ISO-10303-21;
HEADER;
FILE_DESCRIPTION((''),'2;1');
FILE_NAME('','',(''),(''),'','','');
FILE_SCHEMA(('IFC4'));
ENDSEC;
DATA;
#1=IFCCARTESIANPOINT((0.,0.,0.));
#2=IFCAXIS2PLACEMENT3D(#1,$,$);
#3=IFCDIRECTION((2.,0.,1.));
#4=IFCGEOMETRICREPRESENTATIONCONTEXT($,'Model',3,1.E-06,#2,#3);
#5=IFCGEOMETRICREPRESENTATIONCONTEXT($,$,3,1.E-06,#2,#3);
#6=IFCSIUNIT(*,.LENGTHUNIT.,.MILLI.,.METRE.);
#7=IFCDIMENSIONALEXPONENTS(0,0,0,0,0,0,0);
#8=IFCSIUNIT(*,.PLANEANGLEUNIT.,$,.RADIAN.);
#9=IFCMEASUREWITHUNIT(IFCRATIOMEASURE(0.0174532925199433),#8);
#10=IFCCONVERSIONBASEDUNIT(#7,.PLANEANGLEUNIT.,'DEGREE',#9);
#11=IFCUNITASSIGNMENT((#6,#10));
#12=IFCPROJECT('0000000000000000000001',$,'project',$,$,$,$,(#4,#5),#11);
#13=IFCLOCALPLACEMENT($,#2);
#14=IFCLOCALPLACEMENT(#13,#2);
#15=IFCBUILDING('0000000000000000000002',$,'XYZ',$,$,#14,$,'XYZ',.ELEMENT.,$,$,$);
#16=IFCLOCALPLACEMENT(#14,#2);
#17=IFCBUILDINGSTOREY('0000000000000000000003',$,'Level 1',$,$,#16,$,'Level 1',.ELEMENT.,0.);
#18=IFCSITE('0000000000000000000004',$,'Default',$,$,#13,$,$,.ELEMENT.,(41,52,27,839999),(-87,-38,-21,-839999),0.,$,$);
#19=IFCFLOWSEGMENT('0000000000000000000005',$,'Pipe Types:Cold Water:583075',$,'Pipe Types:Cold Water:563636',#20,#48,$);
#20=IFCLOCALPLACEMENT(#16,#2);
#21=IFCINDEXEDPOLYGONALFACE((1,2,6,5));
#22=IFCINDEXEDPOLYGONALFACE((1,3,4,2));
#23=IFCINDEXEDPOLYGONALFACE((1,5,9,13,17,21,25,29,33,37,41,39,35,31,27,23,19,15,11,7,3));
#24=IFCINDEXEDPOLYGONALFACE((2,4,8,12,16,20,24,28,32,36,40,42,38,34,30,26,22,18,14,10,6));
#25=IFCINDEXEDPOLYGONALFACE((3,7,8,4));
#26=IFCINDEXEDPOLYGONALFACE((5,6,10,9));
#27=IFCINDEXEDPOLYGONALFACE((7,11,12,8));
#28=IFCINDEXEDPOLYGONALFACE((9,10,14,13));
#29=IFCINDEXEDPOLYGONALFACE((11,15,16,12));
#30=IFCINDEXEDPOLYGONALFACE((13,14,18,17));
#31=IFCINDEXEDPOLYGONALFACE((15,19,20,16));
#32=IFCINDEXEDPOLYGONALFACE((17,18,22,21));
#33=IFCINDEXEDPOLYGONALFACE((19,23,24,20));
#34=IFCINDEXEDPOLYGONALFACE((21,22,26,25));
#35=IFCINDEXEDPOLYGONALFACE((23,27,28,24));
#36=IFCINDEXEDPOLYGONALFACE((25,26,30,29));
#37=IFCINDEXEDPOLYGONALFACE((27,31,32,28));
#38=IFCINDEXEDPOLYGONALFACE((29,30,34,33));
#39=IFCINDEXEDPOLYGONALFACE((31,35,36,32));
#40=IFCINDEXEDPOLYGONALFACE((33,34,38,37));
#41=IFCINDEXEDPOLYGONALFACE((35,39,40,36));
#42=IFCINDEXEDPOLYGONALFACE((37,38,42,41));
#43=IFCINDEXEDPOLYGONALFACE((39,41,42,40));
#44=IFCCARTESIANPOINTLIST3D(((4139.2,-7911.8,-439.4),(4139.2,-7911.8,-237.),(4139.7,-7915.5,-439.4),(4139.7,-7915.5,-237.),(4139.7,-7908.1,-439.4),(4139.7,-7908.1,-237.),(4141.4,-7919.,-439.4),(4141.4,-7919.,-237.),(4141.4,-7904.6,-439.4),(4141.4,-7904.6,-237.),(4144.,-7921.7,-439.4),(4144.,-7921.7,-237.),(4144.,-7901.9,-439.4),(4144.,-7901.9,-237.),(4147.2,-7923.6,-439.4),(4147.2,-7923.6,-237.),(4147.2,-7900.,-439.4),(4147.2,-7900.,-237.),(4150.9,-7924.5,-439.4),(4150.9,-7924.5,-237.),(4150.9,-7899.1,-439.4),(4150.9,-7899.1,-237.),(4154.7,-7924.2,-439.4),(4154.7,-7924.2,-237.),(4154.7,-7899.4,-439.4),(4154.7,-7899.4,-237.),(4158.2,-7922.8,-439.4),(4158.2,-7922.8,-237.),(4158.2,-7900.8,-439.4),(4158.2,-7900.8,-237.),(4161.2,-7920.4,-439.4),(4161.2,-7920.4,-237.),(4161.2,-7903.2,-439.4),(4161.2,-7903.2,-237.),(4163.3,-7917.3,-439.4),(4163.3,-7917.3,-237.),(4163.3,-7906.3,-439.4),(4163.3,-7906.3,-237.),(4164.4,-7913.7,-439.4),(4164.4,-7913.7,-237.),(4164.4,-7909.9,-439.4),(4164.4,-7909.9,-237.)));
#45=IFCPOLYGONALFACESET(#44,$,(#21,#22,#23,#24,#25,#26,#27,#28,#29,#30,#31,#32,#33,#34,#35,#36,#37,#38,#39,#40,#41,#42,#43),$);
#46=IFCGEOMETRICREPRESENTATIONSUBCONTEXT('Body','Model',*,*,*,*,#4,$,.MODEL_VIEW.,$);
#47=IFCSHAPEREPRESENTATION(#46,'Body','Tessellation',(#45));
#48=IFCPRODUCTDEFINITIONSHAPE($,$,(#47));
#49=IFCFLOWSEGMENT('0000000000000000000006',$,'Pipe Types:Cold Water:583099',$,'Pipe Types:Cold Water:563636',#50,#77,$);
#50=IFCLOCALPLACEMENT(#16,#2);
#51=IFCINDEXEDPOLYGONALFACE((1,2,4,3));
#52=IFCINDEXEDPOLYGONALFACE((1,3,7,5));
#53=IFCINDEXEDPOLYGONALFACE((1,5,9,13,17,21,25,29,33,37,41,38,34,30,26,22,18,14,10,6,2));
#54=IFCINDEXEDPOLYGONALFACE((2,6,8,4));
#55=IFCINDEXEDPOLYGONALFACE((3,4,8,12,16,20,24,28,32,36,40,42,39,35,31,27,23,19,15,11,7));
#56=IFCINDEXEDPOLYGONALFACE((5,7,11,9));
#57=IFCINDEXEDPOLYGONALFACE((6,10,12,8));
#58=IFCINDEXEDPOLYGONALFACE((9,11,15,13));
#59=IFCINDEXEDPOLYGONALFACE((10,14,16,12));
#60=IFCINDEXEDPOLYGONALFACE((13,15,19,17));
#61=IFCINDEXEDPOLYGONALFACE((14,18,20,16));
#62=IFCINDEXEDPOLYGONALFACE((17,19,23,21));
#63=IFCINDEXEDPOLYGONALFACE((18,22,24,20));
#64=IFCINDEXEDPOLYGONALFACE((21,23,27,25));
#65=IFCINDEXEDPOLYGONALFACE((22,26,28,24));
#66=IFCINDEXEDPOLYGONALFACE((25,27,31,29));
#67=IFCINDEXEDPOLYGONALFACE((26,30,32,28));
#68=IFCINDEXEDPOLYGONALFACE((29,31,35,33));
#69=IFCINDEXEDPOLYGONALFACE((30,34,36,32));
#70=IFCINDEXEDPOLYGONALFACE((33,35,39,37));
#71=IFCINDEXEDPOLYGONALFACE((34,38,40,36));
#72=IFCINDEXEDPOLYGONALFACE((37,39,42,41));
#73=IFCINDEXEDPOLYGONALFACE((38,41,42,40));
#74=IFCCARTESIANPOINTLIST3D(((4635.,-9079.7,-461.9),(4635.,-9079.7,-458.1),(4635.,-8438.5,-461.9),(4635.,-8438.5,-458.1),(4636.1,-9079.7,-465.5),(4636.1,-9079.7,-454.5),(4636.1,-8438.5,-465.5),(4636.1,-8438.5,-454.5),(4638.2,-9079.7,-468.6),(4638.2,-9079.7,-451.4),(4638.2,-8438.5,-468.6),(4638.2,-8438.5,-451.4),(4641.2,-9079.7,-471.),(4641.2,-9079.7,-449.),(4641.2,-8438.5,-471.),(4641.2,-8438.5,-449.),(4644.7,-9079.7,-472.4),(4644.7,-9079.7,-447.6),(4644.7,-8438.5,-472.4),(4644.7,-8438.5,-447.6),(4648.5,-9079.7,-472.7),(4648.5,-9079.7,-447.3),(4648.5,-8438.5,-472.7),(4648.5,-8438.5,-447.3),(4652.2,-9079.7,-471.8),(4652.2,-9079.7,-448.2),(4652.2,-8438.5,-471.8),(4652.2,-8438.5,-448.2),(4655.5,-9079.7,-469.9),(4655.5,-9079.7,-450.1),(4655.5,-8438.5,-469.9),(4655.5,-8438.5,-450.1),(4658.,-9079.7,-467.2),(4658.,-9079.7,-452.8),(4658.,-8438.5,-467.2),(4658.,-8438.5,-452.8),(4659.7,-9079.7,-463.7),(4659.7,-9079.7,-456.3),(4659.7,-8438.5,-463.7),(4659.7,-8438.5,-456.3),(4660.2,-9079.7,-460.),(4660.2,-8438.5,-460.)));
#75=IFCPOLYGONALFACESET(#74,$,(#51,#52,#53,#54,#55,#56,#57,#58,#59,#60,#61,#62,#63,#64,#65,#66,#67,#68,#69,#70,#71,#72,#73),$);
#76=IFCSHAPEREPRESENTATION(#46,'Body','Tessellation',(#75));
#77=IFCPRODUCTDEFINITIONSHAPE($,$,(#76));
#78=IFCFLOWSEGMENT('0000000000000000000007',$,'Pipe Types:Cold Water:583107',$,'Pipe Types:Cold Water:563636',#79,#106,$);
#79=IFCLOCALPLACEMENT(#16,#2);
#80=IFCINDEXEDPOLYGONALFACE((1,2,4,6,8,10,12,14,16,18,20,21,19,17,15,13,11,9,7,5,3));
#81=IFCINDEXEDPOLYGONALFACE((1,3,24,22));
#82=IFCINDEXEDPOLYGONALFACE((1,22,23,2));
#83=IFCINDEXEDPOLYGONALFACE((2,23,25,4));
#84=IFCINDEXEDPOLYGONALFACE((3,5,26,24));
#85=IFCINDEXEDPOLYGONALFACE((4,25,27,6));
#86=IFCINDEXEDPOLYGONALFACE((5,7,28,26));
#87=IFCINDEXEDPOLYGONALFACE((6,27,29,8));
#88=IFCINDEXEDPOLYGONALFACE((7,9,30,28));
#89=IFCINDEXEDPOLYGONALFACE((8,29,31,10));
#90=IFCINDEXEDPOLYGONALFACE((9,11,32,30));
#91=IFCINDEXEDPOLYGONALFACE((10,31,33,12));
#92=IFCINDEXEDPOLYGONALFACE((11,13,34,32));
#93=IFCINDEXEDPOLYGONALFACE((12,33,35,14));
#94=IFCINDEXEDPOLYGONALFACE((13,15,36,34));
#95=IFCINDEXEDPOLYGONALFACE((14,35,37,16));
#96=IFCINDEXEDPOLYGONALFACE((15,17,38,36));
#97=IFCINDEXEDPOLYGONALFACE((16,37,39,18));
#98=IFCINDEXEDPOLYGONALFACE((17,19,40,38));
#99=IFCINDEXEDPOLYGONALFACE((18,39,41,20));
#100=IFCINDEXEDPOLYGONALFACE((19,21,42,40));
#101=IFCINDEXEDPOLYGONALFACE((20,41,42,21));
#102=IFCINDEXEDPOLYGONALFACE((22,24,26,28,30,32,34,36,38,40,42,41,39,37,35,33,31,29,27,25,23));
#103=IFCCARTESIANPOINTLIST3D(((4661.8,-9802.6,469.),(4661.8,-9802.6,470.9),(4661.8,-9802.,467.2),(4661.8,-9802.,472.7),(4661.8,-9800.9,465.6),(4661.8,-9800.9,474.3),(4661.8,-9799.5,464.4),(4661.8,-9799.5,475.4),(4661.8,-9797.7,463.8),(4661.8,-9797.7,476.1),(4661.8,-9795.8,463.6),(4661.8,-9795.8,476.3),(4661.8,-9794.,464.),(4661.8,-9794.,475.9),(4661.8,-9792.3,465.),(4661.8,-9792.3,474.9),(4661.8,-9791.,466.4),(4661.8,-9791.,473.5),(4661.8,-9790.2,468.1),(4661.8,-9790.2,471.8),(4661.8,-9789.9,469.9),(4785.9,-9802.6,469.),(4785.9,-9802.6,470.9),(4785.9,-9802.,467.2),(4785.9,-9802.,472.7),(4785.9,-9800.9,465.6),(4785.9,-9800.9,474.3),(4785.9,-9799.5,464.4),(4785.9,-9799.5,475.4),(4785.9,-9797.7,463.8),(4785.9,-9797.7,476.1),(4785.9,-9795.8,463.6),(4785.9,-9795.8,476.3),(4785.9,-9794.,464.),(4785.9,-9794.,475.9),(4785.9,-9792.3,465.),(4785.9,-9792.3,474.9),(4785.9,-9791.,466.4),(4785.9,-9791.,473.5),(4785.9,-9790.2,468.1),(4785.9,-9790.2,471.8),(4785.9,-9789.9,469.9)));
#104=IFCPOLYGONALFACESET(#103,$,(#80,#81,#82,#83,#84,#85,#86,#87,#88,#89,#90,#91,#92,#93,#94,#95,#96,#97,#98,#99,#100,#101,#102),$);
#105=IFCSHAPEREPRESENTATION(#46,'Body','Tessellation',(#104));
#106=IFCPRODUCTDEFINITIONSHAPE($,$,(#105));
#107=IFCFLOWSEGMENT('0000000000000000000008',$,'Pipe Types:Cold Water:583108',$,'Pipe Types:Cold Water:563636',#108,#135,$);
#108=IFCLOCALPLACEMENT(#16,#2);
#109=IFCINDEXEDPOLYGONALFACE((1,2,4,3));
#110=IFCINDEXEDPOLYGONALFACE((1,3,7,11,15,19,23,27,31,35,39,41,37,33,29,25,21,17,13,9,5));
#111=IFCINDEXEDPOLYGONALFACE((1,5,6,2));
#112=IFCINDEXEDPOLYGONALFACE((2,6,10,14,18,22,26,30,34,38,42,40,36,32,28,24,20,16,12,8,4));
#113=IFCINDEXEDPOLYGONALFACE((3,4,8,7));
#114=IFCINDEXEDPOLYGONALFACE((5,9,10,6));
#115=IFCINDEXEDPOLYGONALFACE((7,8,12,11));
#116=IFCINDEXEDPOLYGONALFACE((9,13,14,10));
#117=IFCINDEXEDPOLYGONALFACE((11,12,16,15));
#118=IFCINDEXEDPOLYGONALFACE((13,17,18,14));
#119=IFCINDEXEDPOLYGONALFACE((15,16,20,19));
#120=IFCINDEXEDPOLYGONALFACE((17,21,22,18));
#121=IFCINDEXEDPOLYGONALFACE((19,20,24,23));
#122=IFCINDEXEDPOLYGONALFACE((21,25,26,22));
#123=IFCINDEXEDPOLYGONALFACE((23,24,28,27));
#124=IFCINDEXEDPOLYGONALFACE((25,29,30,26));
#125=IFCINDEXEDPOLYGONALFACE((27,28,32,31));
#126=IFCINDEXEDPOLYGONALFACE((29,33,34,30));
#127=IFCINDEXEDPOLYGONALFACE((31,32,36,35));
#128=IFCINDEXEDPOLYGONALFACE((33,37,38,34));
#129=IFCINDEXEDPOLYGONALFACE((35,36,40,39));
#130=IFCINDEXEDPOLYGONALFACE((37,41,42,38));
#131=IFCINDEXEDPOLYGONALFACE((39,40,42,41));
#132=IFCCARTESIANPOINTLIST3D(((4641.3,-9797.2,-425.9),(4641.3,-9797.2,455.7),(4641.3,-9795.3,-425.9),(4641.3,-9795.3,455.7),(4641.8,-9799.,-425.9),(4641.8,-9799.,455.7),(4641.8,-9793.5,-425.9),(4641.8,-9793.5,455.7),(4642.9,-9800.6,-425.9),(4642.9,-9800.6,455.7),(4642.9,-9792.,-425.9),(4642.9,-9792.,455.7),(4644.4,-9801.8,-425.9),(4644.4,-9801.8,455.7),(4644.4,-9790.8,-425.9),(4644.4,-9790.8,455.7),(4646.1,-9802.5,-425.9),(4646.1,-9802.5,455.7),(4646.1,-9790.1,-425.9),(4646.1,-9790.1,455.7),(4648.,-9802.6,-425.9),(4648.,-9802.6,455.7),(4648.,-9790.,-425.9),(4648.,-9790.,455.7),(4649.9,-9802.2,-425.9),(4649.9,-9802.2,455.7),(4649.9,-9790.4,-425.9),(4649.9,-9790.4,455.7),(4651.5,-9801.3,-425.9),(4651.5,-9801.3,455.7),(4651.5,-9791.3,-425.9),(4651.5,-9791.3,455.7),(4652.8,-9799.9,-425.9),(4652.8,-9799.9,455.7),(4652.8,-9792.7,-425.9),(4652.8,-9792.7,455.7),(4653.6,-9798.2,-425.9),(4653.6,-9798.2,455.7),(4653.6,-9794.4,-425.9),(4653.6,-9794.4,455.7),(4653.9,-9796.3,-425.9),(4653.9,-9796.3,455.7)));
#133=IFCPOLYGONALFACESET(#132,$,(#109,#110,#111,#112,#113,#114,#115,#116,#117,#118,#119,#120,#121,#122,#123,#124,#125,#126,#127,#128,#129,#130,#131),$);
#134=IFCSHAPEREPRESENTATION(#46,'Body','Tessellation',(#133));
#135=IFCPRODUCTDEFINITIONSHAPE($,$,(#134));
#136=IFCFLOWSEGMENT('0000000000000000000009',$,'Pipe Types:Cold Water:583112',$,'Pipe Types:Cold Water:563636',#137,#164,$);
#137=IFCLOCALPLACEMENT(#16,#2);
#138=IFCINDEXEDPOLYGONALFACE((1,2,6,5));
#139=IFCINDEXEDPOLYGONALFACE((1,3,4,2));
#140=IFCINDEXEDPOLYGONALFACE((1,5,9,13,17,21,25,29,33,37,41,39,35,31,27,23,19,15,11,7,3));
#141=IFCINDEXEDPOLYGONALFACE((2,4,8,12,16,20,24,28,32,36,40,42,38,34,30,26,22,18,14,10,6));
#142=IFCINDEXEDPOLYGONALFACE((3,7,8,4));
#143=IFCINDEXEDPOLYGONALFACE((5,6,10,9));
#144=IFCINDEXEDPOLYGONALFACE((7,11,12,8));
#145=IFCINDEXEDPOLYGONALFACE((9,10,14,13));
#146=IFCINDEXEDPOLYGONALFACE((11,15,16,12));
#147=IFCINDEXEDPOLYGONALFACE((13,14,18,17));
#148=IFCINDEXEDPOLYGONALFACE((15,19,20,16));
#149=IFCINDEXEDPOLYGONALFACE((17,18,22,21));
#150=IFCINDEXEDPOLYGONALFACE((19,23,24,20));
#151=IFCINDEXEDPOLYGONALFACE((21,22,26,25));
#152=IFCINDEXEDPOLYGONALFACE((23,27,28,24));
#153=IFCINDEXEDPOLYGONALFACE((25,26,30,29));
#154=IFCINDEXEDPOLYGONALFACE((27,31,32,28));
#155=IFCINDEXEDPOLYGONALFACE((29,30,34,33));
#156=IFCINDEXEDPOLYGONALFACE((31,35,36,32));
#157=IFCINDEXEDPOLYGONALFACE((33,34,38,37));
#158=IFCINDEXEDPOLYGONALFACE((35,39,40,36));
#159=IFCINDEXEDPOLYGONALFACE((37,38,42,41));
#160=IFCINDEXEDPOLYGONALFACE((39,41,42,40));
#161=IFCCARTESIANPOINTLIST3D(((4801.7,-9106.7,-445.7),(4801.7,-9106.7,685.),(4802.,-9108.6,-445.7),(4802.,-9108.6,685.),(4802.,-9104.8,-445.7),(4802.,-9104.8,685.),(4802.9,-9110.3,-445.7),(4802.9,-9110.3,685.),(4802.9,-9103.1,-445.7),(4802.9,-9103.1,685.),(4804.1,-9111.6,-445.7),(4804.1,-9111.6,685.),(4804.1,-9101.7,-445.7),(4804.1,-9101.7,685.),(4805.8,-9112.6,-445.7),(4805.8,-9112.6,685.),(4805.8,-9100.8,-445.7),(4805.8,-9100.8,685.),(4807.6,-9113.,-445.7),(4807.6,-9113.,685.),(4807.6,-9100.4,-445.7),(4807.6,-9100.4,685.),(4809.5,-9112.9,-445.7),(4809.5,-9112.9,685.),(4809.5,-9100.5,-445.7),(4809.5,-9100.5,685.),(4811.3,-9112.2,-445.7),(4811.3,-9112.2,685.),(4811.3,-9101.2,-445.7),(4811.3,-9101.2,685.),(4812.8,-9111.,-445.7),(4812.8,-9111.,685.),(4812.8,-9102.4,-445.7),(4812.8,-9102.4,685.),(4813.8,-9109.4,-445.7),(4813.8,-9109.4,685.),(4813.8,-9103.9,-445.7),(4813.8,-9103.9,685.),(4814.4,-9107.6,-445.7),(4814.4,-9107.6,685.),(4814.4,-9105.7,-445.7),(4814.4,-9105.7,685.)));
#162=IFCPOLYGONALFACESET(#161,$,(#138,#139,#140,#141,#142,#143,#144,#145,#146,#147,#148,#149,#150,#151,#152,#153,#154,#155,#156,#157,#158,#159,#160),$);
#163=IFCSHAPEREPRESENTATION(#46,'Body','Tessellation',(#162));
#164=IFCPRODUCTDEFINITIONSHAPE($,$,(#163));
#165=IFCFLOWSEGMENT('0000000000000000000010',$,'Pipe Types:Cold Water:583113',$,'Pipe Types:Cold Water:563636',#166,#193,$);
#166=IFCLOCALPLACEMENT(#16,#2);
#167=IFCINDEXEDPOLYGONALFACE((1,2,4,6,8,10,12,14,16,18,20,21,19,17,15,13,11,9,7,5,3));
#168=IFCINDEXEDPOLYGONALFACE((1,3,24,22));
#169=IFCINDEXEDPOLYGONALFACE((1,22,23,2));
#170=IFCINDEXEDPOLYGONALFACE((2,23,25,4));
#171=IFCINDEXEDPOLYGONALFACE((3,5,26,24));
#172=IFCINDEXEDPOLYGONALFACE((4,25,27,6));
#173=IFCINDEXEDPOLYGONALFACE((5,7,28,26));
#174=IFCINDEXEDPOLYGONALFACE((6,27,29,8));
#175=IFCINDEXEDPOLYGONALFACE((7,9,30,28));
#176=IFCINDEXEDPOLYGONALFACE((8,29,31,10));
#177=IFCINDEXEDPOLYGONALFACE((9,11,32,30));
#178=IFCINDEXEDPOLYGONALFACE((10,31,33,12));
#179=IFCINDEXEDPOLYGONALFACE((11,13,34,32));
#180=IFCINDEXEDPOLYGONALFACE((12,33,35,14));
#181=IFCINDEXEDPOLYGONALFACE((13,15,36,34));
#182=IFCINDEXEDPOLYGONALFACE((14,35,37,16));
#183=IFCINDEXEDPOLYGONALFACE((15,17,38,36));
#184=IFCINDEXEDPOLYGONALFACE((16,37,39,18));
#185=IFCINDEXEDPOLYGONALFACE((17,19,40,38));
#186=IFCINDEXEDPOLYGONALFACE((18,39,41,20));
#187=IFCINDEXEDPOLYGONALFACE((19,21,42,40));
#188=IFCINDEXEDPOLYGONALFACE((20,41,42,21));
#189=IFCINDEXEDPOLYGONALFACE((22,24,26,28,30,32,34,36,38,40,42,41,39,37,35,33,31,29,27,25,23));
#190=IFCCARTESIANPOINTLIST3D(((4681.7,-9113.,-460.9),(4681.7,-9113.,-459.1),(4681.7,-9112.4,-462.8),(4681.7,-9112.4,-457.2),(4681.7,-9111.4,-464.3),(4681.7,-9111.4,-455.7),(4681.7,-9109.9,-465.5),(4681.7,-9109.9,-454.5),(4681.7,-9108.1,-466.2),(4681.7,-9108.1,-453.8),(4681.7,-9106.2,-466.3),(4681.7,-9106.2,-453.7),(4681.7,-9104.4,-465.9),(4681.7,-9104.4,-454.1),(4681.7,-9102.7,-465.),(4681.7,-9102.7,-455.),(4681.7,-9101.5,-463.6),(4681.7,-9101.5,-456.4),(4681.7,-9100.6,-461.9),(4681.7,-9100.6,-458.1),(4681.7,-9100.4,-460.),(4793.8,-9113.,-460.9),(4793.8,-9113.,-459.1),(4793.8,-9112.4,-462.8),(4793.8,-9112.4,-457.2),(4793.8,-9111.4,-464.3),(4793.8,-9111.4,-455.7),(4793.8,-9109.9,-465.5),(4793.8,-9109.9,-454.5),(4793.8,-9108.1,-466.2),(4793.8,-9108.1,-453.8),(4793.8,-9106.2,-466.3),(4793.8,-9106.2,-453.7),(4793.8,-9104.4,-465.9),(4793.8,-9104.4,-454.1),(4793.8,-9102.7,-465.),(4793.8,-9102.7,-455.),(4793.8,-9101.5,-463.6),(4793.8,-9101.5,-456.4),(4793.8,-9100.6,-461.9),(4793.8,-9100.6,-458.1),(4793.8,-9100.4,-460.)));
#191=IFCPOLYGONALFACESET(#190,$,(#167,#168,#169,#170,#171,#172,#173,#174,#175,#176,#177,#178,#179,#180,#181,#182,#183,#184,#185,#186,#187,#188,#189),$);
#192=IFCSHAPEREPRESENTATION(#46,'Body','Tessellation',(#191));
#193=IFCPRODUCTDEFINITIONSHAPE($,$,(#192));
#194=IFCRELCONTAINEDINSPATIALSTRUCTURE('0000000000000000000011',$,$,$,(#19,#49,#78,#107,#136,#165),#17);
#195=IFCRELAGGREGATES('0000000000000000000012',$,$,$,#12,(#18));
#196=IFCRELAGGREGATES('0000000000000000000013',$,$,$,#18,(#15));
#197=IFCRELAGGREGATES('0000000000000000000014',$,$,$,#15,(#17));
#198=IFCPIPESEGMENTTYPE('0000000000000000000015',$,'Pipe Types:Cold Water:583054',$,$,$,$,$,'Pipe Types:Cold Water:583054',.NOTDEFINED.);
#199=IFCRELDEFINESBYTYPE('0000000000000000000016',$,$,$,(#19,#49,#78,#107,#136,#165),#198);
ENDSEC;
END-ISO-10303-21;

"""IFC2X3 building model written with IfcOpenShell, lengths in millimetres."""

from ifc_helpers import new_model, entity, si_unit, converted_unit, direction, frame, frame_2d, origin, origin_2d_with_axis, place, context, subcontext, project, spatial, circle, extrude, type_object, element, save


model = new_model("IFC2X3")

# Units and contexts
model_context = context("Model", 3, precision=1e-06, world=origin(), true_north=direction((2.0, 0.0, 1.0)))
context_of_model = context(None, 3, precision=1e-06, world=origin(), true_north=direction((2.0, 0.0, 1.0)))
body_context = subcontext(model_context, "Body", "Model", "MODEL_VIEW")
ifc_project = project(units=[si_unit("LENGTHUNIT", "METRE", prefix="MILLI"), converted_unit("PLANEANGLEUNIT", "DEGREE", entity("IfcRatioMeasure", 0.0174532925199433), si_unit("PLANEANGLEUNIT", "RADIAN"), dimensions=[0, 0, 0, 0, 0, 0, 0])], contexts=[model_context, context_of_model])

# Site, building, storey
site_placement = place(None, origin())
site = spatial("IfcSite", under=ifc_project, at=site_placement, Name="Default", CompositionType="ELEMENT", RefLatitude=(41, 52, 27, 839999), RefLongitude=(-87, -38, -21, -839999), RefElevation=0.0)
building_placement = place(site_placement, origin())
building = spatial("IfcBuilding", under=site, at=building_placement, Name="XYZ", LongName="XYZ", CompositionType="ELEMENT")
storey_placement = place(building_placement, origin())
storey = spatial("IfcBuildingStorey", under=building, at=storey_placement, Name="Level 1", LongName="Level 1", CompositionType="ELEMENT", Elevation=0.0)

# Flow segments
pipe_segment_type_1 = type_object("IfcPipeSegmentType", Name="Pipe Types:Cold Water:583054", ElementType="Pipe Types:Cold Water:583054", PredefinedType="NOTDEFINED")
flow_segment_1_placement = place(storey_placement, origin())
element("IfcFlowSegment", 1, at=flow_segment_1_placement, inside=storey, type_object=pipe_segment_type_1, Name="Pipe Types:Cold Water:583075", ObjectType="Pipe Types:Cold Water:563636", context=body_context, shape_type="SweptSolid", body=[
    extrude(circle(Radius=12.7, at=frame_2d((0.0, 0.0), x_axis=(1.0, 0.0))), frame((4151.9, -7911.8, -439.4), z_axis=(0.0, 0.0, 1.0), x_axis=(-1.0, 0.0, 0.0)), (0.0, 0.0, 1.0), 202.4),
])
flow_segment_2_placement = place(storey_placement, origin())
element("IfcFlowSegment", 2, at=flow_segment_2_placement, inside=storey, type_object=pipe_segment_type_1, Name="Pipe Types:Cold Water:583099", ObjectType="Pipe Types:Cold Water:563636", context=body_context, shape_type="SweptSolid", body=[
    extrude(circle(Radius=12.7, at=origin_2d_with_axis()), frame((4647.5, -9079.7, -460.0), z_axis=(0.0, 1.0, 0.0), x_axis=(1.0, 0.0, 0.0)), (0.0, 0.0, 1.0), 641.2),
])
flow_segment_3_placement = place(storey_placement, origin())
element("IfcFlowSegment", 3, at=flow_segment_3_placement, inside=storey, type_object=pipe_segment_type_1, Name="Pipe Types:Cold Water:583107", ObjectType="Pipe Types:Cold Water:563636", context=body_context, shape_type="SweptSolid", body=[
    extrude(circle(Radius=6.3, at=frame_2d((0.0, 0.0), x_axis=(1.0, 0.0))), frame((4661.8, -9796.3, 469.9), z_axis=(1.0, 0.0, 0.0), x_axis=(0.0, 1.0, 0.0)), (0.0, 0.0, 1.0), 124.0),
])
flow_segment_4_placement = place(storey_placement, origin())
element("IfcFlowSegment", 4, at=flow_segment_4_placement, inside=storey, type_object=pipe_segment_type_1, Name="Pipe Types:Cold Water:583108", ObjectType="Pipe Types:Cold Water:563636", context=body_context, shape_type="SweptSolid", body=[
    extrude(circle(Radius=6.3, at=frame_2d((0.0, 0.0), x_axis=(1.0, 0.0))), frame((4647.5, -9796.3, -425.9)), (0.0, 0.0, 1.0), 881.5),
])
flow_segment_5_placement = place(storey_placement, origin())
element("IfcFlowSegment", 5, at=flow_segment_5_placement, inside=storey, type_object=pipe_segment_type_1, Name="Pipe Types:Cold Water:583112", ObjectType="Pipe Types:Cold Water:563636", context=body_context, shape_type="SweptSolid", body=[
    extrude(circle(Radius=6.3, at=frame_2d((0.0, 0.0), x_axis=(1.0, 0.0))), frame((4808.1, -9106.7, -445.7), z_axis=(0.0, 0.0, 1.0), x_axis=(-1.0, 0.0, 0.0)), (0.0, 0.0, 1.0), 1130.7),
])
flow_segment_6_placement = place(storey_placement, origin())
element("IfcFlowSegment", 6, at=flow_segment_6_placement, inside=storey, type_object=pipe_segment_type_1, Name="Pipe Types:Cold Water:583113", ObjectType="Pipe Types:Cold Water:563636", context=body_context, shape_type="SweptSolid", body=[
    extrude(circle(Radius=6.3, at=frame_2d((0.0, 0.0), x_axis=(1.0, 0.0))), frame((4681.7, -9106.7, -460.0), z_axis=(1.0, 0.0, 0.0), x_axis=(0.0, 1.0, 0.0)), (0.0, 0.0, 1.0), 112.1),
])

save(model, "model.ifc")
